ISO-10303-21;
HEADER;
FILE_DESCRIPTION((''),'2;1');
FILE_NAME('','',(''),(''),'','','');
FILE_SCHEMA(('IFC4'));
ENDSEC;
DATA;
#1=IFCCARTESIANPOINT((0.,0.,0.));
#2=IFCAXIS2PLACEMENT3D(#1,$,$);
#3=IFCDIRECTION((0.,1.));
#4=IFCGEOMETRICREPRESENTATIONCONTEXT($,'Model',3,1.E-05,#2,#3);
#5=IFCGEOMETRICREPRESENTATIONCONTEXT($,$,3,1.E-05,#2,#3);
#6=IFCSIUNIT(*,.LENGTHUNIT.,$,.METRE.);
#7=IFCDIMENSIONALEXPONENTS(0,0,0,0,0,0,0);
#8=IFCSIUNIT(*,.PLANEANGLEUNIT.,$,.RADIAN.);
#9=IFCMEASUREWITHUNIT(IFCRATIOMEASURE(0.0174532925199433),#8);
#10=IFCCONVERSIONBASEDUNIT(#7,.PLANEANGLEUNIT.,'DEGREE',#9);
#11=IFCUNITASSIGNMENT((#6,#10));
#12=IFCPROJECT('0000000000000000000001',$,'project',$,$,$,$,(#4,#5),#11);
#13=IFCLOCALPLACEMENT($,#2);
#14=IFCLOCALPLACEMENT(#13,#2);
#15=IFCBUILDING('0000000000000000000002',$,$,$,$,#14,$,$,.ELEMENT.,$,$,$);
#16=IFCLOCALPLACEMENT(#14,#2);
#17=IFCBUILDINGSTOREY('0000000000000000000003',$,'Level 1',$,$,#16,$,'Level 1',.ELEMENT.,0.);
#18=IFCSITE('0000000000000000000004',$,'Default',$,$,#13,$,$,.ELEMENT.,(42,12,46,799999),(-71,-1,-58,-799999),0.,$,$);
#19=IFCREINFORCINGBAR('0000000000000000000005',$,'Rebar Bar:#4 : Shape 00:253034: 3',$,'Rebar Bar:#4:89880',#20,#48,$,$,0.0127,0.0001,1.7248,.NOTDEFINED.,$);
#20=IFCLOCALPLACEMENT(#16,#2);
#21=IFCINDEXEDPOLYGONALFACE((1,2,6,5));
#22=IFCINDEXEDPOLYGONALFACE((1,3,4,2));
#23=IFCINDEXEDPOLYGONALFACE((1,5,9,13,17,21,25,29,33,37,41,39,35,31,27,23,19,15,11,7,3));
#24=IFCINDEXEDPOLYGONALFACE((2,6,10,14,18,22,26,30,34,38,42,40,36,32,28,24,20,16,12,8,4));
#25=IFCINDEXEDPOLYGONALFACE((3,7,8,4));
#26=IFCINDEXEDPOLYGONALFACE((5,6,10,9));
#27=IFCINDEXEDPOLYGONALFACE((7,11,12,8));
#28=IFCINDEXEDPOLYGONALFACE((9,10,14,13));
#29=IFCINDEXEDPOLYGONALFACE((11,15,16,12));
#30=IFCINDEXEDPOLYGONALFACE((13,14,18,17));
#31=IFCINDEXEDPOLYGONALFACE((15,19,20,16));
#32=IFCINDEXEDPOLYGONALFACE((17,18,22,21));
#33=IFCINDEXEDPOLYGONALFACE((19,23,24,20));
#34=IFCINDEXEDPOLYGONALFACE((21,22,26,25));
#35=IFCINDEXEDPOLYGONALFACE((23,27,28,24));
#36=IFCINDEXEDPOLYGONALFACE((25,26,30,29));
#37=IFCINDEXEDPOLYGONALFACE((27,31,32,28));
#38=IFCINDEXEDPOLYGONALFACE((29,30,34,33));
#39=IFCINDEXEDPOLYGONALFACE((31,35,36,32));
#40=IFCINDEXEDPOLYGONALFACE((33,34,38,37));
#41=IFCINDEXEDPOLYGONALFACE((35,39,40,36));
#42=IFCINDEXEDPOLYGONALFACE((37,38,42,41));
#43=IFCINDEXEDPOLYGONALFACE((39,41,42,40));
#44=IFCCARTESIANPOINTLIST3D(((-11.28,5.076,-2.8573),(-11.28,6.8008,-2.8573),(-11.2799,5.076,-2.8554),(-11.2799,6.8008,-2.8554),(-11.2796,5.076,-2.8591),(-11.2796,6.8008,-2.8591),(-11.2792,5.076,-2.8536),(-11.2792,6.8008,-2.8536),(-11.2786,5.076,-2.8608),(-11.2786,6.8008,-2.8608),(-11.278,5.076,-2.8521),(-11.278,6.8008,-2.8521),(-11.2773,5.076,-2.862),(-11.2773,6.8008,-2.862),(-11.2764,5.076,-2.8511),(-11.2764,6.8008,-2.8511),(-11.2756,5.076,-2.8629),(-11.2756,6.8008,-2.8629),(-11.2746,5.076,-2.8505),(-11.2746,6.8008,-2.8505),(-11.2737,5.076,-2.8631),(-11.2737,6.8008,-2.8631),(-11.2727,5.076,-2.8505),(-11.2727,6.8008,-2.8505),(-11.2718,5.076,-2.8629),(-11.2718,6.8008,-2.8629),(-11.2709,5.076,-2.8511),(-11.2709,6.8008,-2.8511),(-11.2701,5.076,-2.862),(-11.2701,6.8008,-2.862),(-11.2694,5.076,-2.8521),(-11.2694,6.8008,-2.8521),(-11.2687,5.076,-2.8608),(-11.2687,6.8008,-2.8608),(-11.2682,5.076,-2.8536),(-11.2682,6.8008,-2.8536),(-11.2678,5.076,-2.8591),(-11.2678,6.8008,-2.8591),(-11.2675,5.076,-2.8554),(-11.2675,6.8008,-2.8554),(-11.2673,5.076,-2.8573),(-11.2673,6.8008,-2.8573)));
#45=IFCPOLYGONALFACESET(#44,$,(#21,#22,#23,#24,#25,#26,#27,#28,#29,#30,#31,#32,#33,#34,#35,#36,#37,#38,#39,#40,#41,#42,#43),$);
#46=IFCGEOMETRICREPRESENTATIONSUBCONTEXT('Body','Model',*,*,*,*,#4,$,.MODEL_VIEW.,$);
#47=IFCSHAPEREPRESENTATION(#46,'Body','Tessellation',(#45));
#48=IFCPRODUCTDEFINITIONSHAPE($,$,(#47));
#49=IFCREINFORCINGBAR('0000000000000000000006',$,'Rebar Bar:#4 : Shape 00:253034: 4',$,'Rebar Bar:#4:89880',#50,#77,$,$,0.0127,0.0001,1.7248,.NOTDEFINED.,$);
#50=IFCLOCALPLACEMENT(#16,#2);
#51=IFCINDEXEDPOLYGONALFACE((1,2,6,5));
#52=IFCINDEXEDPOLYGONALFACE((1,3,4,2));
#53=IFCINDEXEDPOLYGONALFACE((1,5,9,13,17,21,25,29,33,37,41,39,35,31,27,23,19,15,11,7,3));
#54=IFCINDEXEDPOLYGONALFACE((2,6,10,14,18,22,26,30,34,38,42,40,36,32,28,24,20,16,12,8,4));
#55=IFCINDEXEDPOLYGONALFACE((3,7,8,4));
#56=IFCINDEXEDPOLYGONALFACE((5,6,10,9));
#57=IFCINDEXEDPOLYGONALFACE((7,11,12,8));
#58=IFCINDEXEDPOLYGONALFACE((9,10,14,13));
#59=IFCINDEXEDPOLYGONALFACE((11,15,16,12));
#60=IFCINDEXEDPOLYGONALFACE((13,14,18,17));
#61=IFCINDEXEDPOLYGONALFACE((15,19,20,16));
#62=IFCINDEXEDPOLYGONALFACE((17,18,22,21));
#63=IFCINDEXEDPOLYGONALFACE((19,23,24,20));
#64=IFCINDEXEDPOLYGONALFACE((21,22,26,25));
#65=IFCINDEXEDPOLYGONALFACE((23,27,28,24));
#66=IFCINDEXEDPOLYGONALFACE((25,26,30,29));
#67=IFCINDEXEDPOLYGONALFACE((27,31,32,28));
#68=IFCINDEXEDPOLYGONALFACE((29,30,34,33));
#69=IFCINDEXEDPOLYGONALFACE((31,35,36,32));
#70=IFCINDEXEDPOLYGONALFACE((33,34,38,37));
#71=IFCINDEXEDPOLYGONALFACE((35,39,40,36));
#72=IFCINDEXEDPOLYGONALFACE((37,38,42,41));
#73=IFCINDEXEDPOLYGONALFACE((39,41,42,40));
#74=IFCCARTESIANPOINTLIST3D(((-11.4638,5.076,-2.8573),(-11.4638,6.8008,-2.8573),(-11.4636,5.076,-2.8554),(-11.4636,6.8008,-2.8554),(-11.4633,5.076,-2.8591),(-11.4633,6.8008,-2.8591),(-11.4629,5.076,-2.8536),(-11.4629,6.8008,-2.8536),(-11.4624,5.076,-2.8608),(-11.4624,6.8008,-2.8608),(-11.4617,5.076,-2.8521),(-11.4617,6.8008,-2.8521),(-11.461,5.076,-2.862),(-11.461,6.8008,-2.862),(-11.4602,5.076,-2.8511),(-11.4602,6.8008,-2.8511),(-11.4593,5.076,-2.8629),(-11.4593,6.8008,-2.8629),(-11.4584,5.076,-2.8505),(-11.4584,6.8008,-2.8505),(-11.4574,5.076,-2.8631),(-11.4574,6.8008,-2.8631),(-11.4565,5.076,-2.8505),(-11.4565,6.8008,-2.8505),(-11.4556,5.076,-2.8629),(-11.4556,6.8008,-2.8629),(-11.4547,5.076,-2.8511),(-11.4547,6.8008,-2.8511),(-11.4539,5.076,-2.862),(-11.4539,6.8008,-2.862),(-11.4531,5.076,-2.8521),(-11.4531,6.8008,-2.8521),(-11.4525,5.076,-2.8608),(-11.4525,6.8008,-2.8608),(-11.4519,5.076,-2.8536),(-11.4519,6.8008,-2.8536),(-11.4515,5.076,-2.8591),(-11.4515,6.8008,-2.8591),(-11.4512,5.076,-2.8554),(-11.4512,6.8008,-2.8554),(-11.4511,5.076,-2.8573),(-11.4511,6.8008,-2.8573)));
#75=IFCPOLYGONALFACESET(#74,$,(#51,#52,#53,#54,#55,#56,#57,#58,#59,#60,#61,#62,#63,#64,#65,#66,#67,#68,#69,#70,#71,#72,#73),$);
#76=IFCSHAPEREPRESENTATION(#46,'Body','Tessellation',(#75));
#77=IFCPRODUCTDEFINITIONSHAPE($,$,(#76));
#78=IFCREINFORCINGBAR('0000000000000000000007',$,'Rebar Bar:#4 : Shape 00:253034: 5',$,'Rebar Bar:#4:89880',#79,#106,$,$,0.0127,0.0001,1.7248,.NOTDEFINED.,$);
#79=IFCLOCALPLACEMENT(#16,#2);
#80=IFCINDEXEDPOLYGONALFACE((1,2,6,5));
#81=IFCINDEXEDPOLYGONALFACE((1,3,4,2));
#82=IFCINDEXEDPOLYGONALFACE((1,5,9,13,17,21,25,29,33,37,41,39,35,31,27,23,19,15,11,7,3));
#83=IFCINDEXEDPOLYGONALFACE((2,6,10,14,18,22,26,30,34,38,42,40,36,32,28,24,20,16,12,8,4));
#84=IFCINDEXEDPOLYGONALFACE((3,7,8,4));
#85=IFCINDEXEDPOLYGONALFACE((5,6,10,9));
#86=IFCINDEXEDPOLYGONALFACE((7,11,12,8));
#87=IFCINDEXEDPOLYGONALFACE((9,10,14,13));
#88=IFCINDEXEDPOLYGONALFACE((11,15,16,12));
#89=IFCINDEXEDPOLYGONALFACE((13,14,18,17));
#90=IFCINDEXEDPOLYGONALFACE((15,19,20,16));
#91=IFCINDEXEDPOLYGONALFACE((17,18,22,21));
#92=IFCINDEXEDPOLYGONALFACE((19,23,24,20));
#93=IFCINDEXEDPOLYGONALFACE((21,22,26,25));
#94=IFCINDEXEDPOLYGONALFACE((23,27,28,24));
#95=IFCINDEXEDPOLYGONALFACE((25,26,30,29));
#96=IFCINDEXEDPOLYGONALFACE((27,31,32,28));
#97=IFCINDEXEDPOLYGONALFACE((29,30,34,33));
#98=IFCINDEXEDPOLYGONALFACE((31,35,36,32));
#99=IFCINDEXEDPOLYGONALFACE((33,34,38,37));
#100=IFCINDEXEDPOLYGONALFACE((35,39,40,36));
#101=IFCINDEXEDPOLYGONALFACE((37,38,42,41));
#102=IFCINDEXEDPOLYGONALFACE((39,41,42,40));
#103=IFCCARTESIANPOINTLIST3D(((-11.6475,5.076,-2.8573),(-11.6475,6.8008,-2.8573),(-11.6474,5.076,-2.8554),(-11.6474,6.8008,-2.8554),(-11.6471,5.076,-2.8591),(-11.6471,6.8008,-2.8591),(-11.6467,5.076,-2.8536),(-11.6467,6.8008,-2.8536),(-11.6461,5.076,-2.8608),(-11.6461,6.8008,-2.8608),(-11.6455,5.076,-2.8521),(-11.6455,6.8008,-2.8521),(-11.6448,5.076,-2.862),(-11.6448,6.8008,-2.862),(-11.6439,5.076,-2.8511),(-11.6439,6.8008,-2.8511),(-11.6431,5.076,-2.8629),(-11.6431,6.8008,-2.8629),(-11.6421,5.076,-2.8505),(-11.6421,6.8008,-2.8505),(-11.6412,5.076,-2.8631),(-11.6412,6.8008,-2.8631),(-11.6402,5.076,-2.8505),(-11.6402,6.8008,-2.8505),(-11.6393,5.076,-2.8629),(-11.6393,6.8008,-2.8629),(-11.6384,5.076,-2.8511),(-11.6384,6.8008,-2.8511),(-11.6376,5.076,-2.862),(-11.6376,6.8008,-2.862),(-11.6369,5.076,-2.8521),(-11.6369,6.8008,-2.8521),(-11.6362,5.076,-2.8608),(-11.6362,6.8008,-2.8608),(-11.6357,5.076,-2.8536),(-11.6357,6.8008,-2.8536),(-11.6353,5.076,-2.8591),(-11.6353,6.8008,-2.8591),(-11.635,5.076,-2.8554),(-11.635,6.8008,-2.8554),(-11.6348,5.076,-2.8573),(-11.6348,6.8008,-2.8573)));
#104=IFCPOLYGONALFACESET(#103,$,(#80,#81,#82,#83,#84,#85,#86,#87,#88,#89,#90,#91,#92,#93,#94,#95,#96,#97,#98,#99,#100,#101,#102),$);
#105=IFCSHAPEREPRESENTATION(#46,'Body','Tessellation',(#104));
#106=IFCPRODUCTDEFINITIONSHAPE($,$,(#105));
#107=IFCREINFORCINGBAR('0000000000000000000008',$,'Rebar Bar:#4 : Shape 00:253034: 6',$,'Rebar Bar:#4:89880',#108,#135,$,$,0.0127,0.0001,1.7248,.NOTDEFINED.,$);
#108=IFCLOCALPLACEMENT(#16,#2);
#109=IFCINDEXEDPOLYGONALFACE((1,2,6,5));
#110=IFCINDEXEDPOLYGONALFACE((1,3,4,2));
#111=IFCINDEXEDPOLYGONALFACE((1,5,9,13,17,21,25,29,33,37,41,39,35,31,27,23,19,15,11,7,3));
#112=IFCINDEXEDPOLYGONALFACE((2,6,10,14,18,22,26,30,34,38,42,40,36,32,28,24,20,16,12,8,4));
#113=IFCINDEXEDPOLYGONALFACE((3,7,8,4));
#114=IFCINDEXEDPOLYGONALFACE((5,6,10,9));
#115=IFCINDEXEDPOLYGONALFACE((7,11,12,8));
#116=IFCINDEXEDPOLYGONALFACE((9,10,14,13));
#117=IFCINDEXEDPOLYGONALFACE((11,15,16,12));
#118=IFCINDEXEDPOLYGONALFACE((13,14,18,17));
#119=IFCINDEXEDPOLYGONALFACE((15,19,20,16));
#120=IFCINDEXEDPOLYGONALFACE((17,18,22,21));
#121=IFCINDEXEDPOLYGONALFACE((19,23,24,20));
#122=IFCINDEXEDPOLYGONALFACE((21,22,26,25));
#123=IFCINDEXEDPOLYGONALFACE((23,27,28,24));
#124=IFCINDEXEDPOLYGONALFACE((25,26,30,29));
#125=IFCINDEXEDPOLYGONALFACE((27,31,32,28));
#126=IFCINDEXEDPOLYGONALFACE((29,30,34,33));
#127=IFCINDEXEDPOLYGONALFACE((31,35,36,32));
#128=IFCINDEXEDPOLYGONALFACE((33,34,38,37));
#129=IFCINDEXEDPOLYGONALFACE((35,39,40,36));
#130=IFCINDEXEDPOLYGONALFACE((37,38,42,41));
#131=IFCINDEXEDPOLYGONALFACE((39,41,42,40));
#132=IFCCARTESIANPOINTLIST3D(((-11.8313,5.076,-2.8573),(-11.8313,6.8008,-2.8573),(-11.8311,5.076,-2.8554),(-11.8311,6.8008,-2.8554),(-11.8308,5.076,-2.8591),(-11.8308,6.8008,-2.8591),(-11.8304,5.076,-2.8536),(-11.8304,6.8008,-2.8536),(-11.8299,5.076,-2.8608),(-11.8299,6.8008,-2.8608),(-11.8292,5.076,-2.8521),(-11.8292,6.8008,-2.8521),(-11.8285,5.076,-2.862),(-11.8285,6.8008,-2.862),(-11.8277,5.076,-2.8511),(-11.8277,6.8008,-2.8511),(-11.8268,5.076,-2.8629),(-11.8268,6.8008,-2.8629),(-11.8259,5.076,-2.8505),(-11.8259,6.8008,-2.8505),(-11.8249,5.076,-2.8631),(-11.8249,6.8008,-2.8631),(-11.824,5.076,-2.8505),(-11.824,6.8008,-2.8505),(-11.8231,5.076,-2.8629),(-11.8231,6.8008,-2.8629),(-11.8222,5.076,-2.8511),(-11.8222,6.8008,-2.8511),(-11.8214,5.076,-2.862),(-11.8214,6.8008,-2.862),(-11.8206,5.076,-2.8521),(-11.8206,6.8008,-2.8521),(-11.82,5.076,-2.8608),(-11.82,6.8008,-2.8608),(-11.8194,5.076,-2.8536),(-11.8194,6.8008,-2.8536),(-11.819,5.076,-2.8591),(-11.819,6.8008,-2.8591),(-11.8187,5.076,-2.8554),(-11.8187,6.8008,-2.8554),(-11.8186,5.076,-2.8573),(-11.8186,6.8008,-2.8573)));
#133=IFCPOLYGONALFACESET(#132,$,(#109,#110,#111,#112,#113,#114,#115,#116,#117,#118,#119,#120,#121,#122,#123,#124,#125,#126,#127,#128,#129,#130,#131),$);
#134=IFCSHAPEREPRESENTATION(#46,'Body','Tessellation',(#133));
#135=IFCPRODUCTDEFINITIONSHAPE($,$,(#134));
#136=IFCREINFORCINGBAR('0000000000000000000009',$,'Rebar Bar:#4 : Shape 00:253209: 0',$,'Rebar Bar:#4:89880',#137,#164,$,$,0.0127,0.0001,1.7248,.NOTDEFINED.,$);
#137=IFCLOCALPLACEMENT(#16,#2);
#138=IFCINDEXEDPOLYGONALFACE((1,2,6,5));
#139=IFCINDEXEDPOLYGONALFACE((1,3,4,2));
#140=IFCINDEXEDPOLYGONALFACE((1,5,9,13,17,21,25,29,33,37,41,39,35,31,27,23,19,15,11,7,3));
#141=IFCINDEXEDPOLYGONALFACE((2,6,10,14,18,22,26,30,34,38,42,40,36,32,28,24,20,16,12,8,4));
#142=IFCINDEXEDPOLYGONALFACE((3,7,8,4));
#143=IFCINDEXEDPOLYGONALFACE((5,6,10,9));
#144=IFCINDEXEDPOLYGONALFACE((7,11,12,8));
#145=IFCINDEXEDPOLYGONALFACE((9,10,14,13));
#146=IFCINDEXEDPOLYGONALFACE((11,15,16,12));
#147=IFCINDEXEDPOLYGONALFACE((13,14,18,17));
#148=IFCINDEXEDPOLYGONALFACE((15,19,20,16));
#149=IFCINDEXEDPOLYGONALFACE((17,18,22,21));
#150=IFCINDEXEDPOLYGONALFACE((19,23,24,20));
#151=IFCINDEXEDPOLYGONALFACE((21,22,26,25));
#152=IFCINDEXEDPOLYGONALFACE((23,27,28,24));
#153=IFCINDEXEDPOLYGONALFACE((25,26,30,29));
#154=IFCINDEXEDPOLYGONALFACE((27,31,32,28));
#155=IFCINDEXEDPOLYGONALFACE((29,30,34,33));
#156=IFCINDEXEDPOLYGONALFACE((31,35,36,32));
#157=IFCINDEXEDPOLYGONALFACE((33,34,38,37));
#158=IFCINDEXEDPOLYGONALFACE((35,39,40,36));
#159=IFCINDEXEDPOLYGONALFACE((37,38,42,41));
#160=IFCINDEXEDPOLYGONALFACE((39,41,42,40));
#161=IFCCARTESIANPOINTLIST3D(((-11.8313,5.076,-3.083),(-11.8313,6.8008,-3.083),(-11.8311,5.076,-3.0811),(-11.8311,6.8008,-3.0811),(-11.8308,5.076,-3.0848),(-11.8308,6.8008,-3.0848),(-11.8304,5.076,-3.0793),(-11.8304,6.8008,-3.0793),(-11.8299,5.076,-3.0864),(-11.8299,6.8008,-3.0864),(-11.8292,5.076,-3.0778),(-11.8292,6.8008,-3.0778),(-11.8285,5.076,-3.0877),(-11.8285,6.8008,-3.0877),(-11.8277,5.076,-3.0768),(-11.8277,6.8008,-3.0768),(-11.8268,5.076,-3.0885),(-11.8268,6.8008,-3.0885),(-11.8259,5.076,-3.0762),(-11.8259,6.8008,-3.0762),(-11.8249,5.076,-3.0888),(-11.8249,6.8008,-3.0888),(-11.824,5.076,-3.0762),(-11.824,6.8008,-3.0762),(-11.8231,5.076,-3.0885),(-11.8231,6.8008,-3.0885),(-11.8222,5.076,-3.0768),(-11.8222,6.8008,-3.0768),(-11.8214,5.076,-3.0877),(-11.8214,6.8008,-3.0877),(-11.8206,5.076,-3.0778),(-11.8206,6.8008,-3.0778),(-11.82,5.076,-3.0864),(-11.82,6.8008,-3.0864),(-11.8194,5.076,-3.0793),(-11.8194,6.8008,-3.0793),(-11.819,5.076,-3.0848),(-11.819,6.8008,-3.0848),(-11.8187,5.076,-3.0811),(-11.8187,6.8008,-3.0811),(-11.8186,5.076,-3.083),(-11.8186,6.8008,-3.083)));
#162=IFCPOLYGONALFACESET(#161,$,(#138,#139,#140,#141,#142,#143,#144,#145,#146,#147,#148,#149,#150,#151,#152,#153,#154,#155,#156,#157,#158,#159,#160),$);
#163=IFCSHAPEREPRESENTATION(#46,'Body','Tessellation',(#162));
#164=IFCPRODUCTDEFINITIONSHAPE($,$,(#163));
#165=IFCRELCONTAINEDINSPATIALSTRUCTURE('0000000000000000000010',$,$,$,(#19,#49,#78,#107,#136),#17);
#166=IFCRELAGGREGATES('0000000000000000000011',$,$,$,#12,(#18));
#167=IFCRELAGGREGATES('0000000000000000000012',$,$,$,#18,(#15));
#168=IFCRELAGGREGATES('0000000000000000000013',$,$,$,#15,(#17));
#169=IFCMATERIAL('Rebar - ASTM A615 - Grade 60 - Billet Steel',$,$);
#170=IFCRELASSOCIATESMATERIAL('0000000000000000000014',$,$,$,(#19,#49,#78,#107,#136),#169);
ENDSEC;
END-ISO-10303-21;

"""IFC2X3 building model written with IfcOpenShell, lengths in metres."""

from ifc_helpers import new_model, entity, si_unit, converted_unit, direction, origin, place, context, subcontext, project, spatial, material, element, save


model = new_model("IFC2X3")

# Units and contexts
model_context = context("Model", 3, precision=1e-05, world=origin(), true_north=direction((0.0, 1.0)))
context_of_model = context(None, 3, precision=1e-05, world=origin(), true_north=direction((0.0, 1.0)))
body_context = subcontext(model_context, "Body", "Model", "MODEL_VIEW")
ifc_project = project(units=[si_unit("LENGTHUNIT", "METRE"), converted_unit("PLANEANGLEUNIT", "DEGREE", entity("IfcRatioMeasure", 0.0174532925199433), si_unit("PLANEANGLEUNIT", "RADIAN"), dimensions=[0, 0, 0, 0, 0, 0, 0])], contexts=[model_context, context_of_model])

# Site, building, storey
site_placement = place(None, origin())
site = spatial("IfcSite", under=ifc_project, at=site_placement, Name="Default", CompositionType="ELEMENT", RefLatitude=(42, 12, 46, 799999), RefLongitude=(-71, -1, -58, -799999), RefElevation=0.0)
building_placement = place(site_placement, origin())
building = spatial("IfcBuilding", under=site, at=building_placement, CompositionType="ELEMENT")
storey_placement = place(building_placement, origin())
storey = spatial("IfcBuildingStorey", under=building, at=storey_placement, Name="Level 1", LongName="Level 1", CompositionType="ELEMENT", Elevation=0.0)

# Reinforcing bars
ifc_material = material(Name="Rebar - ASTM A615 - Grade 60 - Billet Steel")
reinforcing_bar_1_placement = place(storey_placement, origin())
element("IfcReinforcingBar", 1, at=reinforcing_bar_1_placement, inside=storey, material=ifc_material, Name="Rebar Bar:#4 : Shape 00:253034: 3", ObjectType="Rebar Bar:#4:89880", BarLength=1.7248, BarRole="NOTDEFINED", CrossSectionArea=0.0001, NominalDiameter=0.0127, context=body_context, shape_type="AdvancedSweptSolid", body=[
    entity("IfcSweptDiskSolid", entity("IfcCompositeCurve", [entity("IfcCompositeCurveSegment", "CONTINUOUS", True, entity("IfcPolyline", [entity("IfcCartesianPoint", [-11.2737, 6.8008, -2.8568]), entity("IfcCartesianPoint", [-11.2737, 5.076, -2.8568])]))], False), 0.0063, None, 0.0, 1.0),
])
reinforcing_bar_2_placement = place(storey_placement, origin())
element("IfcReinforcingBar", 2, at=reinforcing_bar_2_placement, inside=storey, material=ifc_material, Name="Rebar Bar:#4 : Shape 00:253034: 4", ObjectType="Rebar Bar:#4:89880", BarLength=1.7248, BarRole="NOTDEFINED", CrossSectionArea=0.0001, NominalDiameter=0.0127, context=body_context, shape_type="AdvancedSweptSolid", body=[
    entity("IfcSweptDiskSolid", entity("IfcCompositeCurve", [entity("IfcCompositeCurveSegment", "CONTINUOUS", True, entity("IfcPolyline", [entity("IfcCartesianPoint", [-11.4574, 6.8008, -2.8568]), entity("IfcCartesianPoint", [-11.4574, 5.076, -2.8568])]))], False), 0.0063, None, 0.0, 1.0),
])
reinforcing_bar_3_placement = place(storey_placement, origin())
element("IfcReinforcingBar", 3, at=reinforcing_bar_3_placement, inside=storey, material=ifc_material, Name="Rebar Bar:#4 : Shape 00:253034: 5", ObjectType="Rebar Bar:#4:89880", BarLength=1.7248, BarRole="NOTDEFINED", CrossSectionArea=0.0001, NominalDiameter=0.0127, context=body_context, shape_type="AdvancedSweptSolid", body=[
    entity("IfcSweptDiskSolid", entity("IfcCompositeCurve", [entity("IfcCompositeCurveSegment", "CONTINUOUS", True, entity("IfcPolyline", [entity("IfcCartesianPoint", [-11.6412, 6.8008, -2.8568]), entity("IfcCartesianPoint", [-11.6412, 5.076, -2.8568])]))], False), 0.0063, None, 0.0, 1.0),
])
reinforcing_bar_4_placement = place(storey_placement, origin())
element("IfcReinforcingBar", 4, at=reinforcing_bar_4_placement, inside=storey, material=ifc_material, Name="Rebar Bar:#4 : Shape 00:253034: 6", ObjectType="Rebar Bar:#4:89880", BarLength=1.7248, BarRole="NOTDEFINED", CrossSectionArea=0.0001, NominalDiameter=0.0127, context=body_context, shape_type="AdvancedSweptSolid", body=[
    entity("IfcSweptDiskSolid", entity("IfcCompositeCurve", [entity("IfcCompositeCurveSegment", "CONTINUOUS", True, entity("IfcPolyline", [entity("IfcCartesianPoint", [-11.8249, 6.8008, -2.8568]), entity("IfcCartesianPoint", [-11.8249, 5.076, -2.8568])]))], False), 0.0063, None, 0.0, 1.0),
])
reinforcing_bar_5_placement = place(storey_placement, origin())
element("IfcReinforcingBar", 5, at=reinforcing_bar_5_placement, inside=storey, material=ifc_material, Name="Rebar Bar:#4 : Shape 00:253209: 0", ObjectType="Rebar Bar:#4:89880", BarLength=1.7248, BarRole="NOTDEFINED", CrossSectionArea=0.0001, NominalDiameter=0.0127, context=body_context, shape_type="AdvancedSweptSolid", body=[
    entity("IfcSweptDiskSolid", entity("IfcCompositeCurve", [entity("IfcCompositeCurveSegment", "CONTINUOUS", True, entity("IfcPolyline", [entity("IfcCartesianPoint", [-11.8249, 6.8008, -3.0825]), entity("IfcCartesianPoint", [-11.8249, 5.076, -3.0825])]))], False), 0.0063, None, 0.0, 1.0),
])

save(model, "model.ifc")
